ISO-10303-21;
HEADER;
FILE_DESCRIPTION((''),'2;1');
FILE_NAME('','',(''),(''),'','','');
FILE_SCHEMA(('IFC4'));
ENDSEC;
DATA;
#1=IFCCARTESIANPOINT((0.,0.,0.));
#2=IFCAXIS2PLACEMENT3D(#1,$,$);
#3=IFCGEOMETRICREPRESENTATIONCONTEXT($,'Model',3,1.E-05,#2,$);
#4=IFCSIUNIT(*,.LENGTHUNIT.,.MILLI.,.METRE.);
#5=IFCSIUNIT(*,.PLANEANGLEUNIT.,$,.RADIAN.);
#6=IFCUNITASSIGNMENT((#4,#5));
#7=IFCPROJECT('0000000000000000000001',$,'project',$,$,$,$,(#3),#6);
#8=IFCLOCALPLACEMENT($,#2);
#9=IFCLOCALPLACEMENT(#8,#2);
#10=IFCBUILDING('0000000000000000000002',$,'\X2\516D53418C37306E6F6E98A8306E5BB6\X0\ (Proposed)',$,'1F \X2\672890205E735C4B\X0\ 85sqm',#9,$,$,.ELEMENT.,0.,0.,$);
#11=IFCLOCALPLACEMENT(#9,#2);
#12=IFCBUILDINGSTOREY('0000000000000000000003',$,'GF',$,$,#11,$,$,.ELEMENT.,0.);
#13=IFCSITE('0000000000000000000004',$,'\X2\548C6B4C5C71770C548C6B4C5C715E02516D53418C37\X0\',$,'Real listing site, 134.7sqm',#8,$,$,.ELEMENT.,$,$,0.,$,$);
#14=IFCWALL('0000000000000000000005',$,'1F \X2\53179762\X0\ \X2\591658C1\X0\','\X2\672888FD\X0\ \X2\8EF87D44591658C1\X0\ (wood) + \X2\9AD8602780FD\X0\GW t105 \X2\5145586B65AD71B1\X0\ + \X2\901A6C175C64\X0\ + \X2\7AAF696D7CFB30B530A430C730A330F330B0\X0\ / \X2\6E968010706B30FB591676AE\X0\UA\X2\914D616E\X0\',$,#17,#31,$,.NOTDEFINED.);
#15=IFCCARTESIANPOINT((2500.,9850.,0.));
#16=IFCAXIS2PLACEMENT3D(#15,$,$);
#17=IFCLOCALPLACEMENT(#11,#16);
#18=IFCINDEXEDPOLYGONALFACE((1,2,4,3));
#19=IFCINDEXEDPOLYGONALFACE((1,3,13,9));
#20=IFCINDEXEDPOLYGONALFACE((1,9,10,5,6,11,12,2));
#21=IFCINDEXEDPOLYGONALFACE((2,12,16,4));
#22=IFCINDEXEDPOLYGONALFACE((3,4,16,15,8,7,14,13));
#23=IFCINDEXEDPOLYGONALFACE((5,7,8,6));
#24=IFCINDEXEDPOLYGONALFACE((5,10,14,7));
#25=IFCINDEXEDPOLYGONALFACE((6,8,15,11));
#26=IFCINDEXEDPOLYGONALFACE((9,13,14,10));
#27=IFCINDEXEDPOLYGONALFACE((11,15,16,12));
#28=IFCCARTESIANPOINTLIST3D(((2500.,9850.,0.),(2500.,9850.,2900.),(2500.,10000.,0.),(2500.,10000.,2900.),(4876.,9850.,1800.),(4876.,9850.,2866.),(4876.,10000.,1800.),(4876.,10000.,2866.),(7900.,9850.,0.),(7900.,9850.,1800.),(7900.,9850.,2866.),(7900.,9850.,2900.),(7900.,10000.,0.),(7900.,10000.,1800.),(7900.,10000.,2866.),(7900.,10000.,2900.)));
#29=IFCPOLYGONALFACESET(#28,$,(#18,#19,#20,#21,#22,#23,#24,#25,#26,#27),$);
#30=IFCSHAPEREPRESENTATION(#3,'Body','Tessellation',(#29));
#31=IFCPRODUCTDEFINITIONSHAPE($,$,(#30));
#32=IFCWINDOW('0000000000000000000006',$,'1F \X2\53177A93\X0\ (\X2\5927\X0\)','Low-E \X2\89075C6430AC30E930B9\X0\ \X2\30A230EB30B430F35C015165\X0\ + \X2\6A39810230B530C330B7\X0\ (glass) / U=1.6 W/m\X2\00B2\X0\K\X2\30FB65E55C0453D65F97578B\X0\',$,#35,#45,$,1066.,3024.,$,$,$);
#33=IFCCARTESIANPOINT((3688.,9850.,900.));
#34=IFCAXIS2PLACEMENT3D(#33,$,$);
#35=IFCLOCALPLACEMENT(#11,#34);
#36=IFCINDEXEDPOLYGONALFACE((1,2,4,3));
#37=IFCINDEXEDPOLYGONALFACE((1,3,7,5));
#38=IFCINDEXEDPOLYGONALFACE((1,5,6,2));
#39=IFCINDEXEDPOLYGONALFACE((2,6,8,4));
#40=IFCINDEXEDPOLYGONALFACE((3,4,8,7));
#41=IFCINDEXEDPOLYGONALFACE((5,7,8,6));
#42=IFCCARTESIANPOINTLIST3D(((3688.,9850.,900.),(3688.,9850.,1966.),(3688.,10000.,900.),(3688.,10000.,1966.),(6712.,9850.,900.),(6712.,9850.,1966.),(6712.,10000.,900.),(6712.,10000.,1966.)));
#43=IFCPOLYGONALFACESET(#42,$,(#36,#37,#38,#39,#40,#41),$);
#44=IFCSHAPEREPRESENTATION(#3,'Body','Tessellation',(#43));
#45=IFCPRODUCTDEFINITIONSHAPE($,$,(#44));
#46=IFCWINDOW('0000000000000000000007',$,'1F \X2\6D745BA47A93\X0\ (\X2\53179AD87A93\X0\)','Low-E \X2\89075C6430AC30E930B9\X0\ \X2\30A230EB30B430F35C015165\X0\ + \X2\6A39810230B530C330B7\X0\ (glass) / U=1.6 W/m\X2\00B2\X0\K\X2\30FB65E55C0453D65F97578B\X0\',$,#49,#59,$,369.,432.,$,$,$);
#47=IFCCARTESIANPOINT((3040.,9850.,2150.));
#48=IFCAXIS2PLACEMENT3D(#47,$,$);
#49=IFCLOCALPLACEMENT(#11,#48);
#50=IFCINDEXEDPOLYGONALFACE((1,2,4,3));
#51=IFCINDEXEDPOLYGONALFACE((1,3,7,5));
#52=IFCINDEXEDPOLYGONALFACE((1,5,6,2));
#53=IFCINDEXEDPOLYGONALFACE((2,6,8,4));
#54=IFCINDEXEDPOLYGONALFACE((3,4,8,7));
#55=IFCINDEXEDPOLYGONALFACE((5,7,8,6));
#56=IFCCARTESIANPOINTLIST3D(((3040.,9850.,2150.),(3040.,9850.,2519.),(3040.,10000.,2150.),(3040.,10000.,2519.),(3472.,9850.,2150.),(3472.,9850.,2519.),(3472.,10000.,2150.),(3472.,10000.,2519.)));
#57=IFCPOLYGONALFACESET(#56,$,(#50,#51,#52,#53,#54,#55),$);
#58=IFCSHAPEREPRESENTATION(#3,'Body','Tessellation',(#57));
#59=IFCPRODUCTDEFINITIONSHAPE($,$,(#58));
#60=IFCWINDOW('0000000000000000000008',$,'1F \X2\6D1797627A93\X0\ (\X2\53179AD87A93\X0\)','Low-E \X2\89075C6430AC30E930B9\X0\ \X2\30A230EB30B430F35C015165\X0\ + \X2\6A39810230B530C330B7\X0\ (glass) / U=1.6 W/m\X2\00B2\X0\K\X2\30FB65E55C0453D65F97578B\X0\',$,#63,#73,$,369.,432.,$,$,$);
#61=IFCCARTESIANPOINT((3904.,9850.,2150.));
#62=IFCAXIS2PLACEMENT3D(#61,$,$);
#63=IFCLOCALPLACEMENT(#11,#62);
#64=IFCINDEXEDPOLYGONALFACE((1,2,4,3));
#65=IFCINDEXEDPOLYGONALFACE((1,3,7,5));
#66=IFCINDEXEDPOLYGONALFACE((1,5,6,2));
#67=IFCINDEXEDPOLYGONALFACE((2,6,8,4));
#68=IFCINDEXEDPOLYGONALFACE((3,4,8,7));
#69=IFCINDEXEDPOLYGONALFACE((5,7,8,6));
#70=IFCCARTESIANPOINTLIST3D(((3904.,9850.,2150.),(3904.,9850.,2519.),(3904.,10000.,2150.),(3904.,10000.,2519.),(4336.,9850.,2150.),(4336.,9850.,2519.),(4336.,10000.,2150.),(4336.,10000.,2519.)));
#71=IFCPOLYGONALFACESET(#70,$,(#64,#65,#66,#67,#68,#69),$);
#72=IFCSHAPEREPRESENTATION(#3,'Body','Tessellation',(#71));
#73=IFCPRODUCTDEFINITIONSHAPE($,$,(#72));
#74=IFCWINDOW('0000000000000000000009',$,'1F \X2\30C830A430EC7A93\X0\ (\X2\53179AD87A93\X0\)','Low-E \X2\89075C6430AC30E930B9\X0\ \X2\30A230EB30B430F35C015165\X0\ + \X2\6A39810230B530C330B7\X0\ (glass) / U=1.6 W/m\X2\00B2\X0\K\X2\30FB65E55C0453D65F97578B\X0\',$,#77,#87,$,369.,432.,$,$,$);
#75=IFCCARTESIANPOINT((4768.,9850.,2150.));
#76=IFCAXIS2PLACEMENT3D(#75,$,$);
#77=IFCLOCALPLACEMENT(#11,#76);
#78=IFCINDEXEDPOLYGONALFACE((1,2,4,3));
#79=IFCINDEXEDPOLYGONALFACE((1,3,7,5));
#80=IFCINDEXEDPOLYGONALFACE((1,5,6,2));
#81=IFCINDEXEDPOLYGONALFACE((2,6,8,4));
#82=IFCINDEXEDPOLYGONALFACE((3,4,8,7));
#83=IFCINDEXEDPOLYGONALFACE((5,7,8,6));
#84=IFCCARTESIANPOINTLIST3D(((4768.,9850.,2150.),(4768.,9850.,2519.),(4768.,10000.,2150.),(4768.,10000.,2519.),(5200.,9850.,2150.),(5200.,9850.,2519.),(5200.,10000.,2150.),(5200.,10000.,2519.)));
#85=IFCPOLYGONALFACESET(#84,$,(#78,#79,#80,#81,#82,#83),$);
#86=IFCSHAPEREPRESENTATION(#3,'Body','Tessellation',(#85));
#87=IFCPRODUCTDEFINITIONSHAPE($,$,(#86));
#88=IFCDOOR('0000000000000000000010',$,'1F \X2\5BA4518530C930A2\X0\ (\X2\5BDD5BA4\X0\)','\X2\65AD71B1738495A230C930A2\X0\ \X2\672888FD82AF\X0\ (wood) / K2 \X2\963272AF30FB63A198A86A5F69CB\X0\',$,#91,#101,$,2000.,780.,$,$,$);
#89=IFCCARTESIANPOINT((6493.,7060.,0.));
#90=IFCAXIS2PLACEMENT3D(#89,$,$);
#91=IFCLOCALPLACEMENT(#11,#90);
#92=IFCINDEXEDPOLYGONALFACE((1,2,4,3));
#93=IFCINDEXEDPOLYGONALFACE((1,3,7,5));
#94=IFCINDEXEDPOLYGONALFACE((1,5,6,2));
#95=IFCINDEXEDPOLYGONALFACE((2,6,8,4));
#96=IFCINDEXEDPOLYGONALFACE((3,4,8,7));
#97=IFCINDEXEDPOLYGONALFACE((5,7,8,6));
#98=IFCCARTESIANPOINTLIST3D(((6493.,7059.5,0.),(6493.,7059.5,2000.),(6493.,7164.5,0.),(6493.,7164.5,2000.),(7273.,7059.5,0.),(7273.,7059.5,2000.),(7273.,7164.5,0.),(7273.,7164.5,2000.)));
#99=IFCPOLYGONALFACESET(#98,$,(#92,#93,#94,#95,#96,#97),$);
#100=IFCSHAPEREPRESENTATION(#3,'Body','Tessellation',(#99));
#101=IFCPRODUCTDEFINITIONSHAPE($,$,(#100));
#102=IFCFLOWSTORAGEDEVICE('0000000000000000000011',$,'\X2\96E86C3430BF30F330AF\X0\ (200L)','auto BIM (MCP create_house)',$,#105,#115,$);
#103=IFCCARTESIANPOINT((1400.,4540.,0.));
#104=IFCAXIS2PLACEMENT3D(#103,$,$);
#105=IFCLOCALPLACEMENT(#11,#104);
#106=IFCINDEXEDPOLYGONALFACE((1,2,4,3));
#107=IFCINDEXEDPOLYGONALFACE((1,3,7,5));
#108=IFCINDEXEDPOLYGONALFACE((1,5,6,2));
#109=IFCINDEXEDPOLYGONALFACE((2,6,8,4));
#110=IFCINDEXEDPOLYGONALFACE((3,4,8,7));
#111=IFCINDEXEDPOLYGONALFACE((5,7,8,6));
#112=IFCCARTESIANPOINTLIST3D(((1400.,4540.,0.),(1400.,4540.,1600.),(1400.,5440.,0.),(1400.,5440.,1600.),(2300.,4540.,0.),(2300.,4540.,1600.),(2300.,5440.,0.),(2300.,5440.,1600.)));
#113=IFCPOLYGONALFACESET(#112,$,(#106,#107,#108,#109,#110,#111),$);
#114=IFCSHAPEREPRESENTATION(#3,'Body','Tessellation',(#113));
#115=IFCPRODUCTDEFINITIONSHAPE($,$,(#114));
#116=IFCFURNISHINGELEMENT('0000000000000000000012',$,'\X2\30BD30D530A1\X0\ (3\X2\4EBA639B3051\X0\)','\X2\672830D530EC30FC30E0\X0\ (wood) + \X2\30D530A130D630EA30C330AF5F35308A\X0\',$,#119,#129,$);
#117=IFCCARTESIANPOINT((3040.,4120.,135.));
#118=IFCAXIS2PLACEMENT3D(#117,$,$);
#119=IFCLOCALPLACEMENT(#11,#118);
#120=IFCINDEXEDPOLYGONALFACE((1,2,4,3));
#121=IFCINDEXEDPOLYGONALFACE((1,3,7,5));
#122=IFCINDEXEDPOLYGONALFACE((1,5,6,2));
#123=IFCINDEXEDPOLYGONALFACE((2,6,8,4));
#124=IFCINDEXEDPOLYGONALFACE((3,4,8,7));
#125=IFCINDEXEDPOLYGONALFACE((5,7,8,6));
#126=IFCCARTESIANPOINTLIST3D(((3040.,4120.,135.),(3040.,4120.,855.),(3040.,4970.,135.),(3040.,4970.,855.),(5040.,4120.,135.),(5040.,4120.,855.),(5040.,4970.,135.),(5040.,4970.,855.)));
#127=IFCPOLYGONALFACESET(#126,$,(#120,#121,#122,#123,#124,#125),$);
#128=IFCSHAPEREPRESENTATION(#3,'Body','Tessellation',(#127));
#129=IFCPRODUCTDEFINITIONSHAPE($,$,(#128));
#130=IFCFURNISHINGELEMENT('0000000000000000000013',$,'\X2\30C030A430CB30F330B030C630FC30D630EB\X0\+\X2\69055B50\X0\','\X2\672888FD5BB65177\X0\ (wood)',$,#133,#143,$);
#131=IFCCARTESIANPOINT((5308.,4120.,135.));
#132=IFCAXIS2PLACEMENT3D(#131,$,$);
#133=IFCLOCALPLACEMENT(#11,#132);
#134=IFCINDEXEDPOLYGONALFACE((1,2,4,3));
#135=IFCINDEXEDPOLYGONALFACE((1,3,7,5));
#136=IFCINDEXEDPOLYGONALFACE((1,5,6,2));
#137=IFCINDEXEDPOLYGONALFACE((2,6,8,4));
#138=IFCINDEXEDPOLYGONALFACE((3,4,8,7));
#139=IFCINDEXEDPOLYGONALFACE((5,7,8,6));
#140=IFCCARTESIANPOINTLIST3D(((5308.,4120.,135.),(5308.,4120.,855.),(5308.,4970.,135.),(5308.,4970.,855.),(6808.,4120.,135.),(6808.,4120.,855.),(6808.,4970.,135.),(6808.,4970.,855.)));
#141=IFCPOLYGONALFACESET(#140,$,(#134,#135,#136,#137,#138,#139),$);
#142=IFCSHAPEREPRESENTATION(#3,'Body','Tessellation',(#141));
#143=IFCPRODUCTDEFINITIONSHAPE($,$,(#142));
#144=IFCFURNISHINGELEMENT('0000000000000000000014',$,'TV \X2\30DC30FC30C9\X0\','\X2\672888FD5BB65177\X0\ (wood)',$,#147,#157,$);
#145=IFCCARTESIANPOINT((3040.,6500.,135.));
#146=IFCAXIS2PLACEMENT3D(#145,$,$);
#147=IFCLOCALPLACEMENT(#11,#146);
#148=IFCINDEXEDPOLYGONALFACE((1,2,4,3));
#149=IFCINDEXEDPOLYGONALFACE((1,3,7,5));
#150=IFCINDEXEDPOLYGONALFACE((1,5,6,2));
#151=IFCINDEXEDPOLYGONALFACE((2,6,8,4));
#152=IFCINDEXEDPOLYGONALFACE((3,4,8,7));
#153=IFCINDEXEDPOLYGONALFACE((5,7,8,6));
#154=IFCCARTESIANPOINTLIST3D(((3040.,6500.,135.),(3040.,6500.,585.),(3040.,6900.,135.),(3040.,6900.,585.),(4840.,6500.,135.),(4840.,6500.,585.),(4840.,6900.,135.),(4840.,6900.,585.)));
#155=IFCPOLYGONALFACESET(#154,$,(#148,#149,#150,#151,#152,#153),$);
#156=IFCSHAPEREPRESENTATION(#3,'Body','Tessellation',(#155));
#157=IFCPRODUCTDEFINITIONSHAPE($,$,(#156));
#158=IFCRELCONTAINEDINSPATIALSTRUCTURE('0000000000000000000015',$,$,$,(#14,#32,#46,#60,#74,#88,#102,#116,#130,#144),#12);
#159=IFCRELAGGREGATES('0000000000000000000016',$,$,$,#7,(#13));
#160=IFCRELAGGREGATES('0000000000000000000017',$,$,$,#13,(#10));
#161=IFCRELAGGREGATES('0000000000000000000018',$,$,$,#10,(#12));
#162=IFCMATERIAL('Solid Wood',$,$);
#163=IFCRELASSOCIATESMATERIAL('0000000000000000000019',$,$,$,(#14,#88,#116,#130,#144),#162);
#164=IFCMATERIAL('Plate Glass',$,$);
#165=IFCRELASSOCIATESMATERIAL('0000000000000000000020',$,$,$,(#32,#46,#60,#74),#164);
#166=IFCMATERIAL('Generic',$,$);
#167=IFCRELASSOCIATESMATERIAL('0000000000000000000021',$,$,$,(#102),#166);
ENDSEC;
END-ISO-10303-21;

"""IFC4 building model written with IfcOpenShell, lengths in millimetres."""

from ifc_helpers import new_model, si_unit, frame, frame_2d, origin, place, context, project, spatial, rectangle, extrude, material, element, fill, save


model = new_model("IFC4")

# Units and contexts
model_context = context("Model", 3, precision=1e-05, world=origin())
ifc_project = project(units=[si_unit("LENGTHUNIT", "METRE", prefix="MILLI"), si_unit("PLANEANGLEUNIT", "RADIAN")], contexts=[model_context])

# Site, building, storey
site_placement = place(None, origin())
site = spatial("IfcSite", under=ifc_project, at=site_placement, Name="和歌山県和歌山市六十谷", ObjectType="Real listing site, 134.7sqm", CompositionType="ELEMENT", RefElevation=0.0)
building_placement = place(site_placement, origin())
building = spatial("IfcBuilding", under=site, at=building_placement, Name="六十谷の潮風の家 (Proposed)", ObjectType="1F 木造平屋 85sqm", CompositionType="ELEMENT", ElevationOfRefHeight=0.0, ElevationOfTerrain=0.0)
storey_placement = place(building_placement, origin())
storey = spatial("IfcBuildingStorey", under=building, at=storey_placement, Name="GF", CompositionType="ELEMENT", Elevation=0.0)

# Wall, openings, windows
ifc_material_1 = material(Name="Solid Wood")
wall_1_placement = place(storey_placement, frame((2500.0, 9850.0, 0.0)))
wall_1 = element("IfcWall", 1, at=wall_1_placement, inside=storey, material=ifc_material_1, Name="1F 北面 外壁", Description="木製 軸組外壁 (wood) + 高性能GW t105 充填断熱 + 通気層 + 窯業系サイディング / 準耐火・外皮UA配慮", PredefinedType="NOTDEFINED", context=model_context, shape_type="SweptSolid", body=[
    extrude(rectangle(XDim=5400.0, YDim=150.0, at=frame_2d((2700.0, 75.0))), frame((2500.0, 9850.0, 0.0)), (0.0, 0.0, 1.0), 2900.0),
])
opening_1_placement = place(storey_placement, frame((3688.0, 9850.0, 900.0)))
opening_1 = element("IfcOpeningElement", 2, at=opening_1_placement, cuts=wall_1, PredefinedType="NOTDEFINED", context=model_context, shape_type="SweptSolid", body=[
    extrude(rectangle(XDim=3024.0, YDim=150.0, at=frame_2d((1512.0, 75.0))), frame((3688.0, 9850.0, 900.0)), (0.0, 0.0, 1.0), 1066.0),
])
opening_2_placement = place(storey_placement, frame((3040.0, 9850.0, 2150.0)))
opening_2 = element("IfcOpeningElement", 3, at=opening_2_placement, cuts=wall_1, PredefinedType="NOTDEFINED", context=model_context, shape_type="SweptSolid", body=[
    extrude(rectangle(XDim=432.0, YDim=150.0, at=frame_2d((216.0, 75.0))), frame((3040.0, 9850.0, 2150.0)), (0.0, 0.0, 1.0), 369.0),
])
opening_3_placement = place(storey_placement, frame((3904.0, 9850.0, 2150.0)))
opening_3 = element("IfcOpeningElement", 4, at=opening_3_placement, cuts=wall_1, PredefinedType="NOTDEFINED", context=model_context, shape_type="SweptSolid", body=[
    extrude(rectangle(XDim=432.0, YDim=150.0, at=frame_2d((216.0, 75.0))), frame((3904.0, 9850.0, 2150.0)), (0.0, 0.0, 1.0), 369.0),
])
opening_4_placement = place(storey_placement, frame((4768.0, 9850.0, 2150.0)))
opening_4 = element("IfcOpeningElement", 5, at=opening_4_placement, cuts=wall_1, PredefinedType="NOTDEFINED", context=model_context, shape_type="SweptSolid", body=[
    extrude(rectangle(XDim=432.0, YDim=150.0, at=frame_2d((216.0, 75.0))), frame((4768.0, 9850.0, 2150.0)), (0.0, 0.0, 1.0), 369.0),
])
ifc_material_2 = material(Name="Plate Glass")
window_1_placement = place(storey_placement, frame((3688.0, 9850.0, 900.0)))
window_1 = element("IfcWindow", 6, at=window_1_placement, inside=storey, material=ifc_material_2, Name="1F 北窓 (大)", Description="Low-E 複層ガラス アルゴン封入 + 樹脂サッシ (glass) / U=1.6 W/m²K・日射取得型", OverallHeight=1066.0, OverallWidth=3024.0, context=model_context, shape_type="SweptSolid", body=[
    extrude(rectangle(XDim=3024.0, YDim=150.0, at=frame_2d((1512.0, 75.0))), frame((3688.0, 9850.0, 900.0)), (0.0, 0.0, 1.0), 1066.0),
])
fill(opening_1, window_1)
window_2_placement = place(storey_placement, frame((3040.0, 9850.0, 2150.0)))
window_2 = element("IfcWindow", 7, at=window_2_placement, inside=storey, material=ifc_material_2, Name="1F 浴室窓 (北高窓)", Description="Low-E 複層ガラス アルゴン封入 + 樹脂サッシ (glass) / U=1.6 W/m²K・日射取得型", OverallHeight=369.0, OverallWidth=432.0, context=model_context, shape_type="SweptSolid", body=[
    extrude(rectangle(XDim=432.0, YDim=150.0, at=frame_2d((216.0, 75.0))), frame((3040.0, 9850.0, 2150.0)), (0.0, 0.0, 1.0), 369.0),
])
fill(opening_2, window_2)
window_3_placement = place(storey_placement, frame((3904.0, 9850.0, 2150.0)))
window_3 = element("IfcWindow", 8, at=window_3_placement, inside=storey, material=ifc_material_2, Name="1F 洗面窓 (北高窓)", Description="Low-E 複層ガラス アルゴン封入 + 樹脂サッシ (glass) / U=1.6 W/m²K・日射取得型", OverallHeight=369.0, OverallWidth=432.0, context=model_context, shape_type="SweptSolid", body=[
    extrude(rectangle(XDim=432.0, YDim=150.0, at=frame_2d((216.0, 75.0))), frame((3904.0, 9850.0, 2150.0)), (0.0, 0.0, 1.0), 369.0),
])
fill(opening_3, window_3)
window_4_placement = place(storey_placement, frame((4768.0, 9850.0, 2150.0)))
window_4 = element("IfcWindow", 9, at=window_4_placement, inside=storey, material=ifc_material_2, Name="1F トイレ窓 (北高窓)", Description="Low-E 複層ガラス アルゴン封入 + 樹脂サッシ (glass) / U=1.6 W/m²K・日射取得型", OverallHeight=369.0, OverallWidth=432.0, context=model_context, shape_type="SweptSolid", body=[
    extrude(rectangle(XDim=432.0, YDim=150.0, at=frame_2d((216.0, 75.0))), frame((4768.0, 9850.0, 2150.0)), (0.0, 0.0, 1.0), 369.0),
])
fill(opening_4, window_4)

# Door
door_1_placement = place(storey_placement, frame((6493.0, 7060.0, 0.0)))
element("IfcDoor", 10, at=door_1_placement, inside=storey, material=ifc_material_1, Name="1F 室内ドア (寝室)", Description="断熱玄関ドア 木製芯 (wood) / K2 防犯・採風機構", OverallHeight=2000.0, OverallWidth=780.0, context=model_context, shape_type="SweptSolid", body=[
    extrude(rectangle(XDim=780.0, YDim=105.0, at=frame_2d((390.0, 52.0))), frame((6493.0, 7060.0, 0.0)), (0.0, 0.0, 1.0), 2000.0),
])

# Flow storage device
ifc_material_3 = material(Name="Generic")
flow_storage_device_placement = place(storey_placement, frame((1400.0, 4540.0, 0.0)))
element("IfcFlowStorageDevice", 11, at=flow_storage_device_placement, inside=storey, material=ifc_material_3, Name="雨水タンク (200L)", Description="auto BIM (MCP create_house)", context=model_context, shape_type="SweptSolid", body=[
    extrude(rectangle(XDim=900.0, YDim=900.0, at=frame_2d((450.0, 450.0))), frame((1400.0, 4540.0, 0.0)), (0.0, 0.0, 1.0), 1600.0),
])

# Furnishing elements
furnishing_1_placement = place(storey_placement, frame((3040.0, 4120.0, 135.0)))
element("IfcFurnishingElement", 12, at=furnishing_1_placement, inside=storey, material=ifc_material_1, Name="ソファ (3人掛け)", Description="木フレーム (wood) + ファブリック張り", context=model_context, shape_type="SweptSolid", body=[
    extrude(rectangle(XDim=2000.0, YDim=850.0, at=frame_2d((1000.0, 425.0))), frame((3040.0, 4120.0, 135.0)), (0.0, 0.0, 1.0), 720.0),
])
furnishing_2_placement = place(storey_placement, frame((5308.0, 4120.0, 135.0)))
element("IfcFurnishingElement", 13, at=furnishing_2_placement, inside=storey, material=ifc_material_1, Name="ダイニングテーブル+椅子", Description="木製家具 (wood)", context=model_context, shape_type="SweptSolid", body=[
    extrude(rectangle(XDim=1500.0, YDim=850.0, at=frame_2d((750.0, 425.0))), frame((5308.0, 4120.0, 135.0)), (0.0, 0.0, 1.0), 720.0),
])
furnishing_3_placement = place(storey_placement, frame((3040.0, 6500.0, 135.0)))
element("IfcFurnishingElement", 14, at=furnishing_3_placement, inside=storey, material=ifc_material_1, Name="TV ボード", Description="木製家具 (wood)", context=model_context, shape_type="SweptSolid", body=[
    extrude(rectangle(XDim=1800.0, YDim=400.0, at=frame_2d((900.0, 200.0))), frame((3040.0, 6500.0, 135.0)), (0.0, 0.0, 1.0), 450.0),
])

save(model, "model.ifc")
